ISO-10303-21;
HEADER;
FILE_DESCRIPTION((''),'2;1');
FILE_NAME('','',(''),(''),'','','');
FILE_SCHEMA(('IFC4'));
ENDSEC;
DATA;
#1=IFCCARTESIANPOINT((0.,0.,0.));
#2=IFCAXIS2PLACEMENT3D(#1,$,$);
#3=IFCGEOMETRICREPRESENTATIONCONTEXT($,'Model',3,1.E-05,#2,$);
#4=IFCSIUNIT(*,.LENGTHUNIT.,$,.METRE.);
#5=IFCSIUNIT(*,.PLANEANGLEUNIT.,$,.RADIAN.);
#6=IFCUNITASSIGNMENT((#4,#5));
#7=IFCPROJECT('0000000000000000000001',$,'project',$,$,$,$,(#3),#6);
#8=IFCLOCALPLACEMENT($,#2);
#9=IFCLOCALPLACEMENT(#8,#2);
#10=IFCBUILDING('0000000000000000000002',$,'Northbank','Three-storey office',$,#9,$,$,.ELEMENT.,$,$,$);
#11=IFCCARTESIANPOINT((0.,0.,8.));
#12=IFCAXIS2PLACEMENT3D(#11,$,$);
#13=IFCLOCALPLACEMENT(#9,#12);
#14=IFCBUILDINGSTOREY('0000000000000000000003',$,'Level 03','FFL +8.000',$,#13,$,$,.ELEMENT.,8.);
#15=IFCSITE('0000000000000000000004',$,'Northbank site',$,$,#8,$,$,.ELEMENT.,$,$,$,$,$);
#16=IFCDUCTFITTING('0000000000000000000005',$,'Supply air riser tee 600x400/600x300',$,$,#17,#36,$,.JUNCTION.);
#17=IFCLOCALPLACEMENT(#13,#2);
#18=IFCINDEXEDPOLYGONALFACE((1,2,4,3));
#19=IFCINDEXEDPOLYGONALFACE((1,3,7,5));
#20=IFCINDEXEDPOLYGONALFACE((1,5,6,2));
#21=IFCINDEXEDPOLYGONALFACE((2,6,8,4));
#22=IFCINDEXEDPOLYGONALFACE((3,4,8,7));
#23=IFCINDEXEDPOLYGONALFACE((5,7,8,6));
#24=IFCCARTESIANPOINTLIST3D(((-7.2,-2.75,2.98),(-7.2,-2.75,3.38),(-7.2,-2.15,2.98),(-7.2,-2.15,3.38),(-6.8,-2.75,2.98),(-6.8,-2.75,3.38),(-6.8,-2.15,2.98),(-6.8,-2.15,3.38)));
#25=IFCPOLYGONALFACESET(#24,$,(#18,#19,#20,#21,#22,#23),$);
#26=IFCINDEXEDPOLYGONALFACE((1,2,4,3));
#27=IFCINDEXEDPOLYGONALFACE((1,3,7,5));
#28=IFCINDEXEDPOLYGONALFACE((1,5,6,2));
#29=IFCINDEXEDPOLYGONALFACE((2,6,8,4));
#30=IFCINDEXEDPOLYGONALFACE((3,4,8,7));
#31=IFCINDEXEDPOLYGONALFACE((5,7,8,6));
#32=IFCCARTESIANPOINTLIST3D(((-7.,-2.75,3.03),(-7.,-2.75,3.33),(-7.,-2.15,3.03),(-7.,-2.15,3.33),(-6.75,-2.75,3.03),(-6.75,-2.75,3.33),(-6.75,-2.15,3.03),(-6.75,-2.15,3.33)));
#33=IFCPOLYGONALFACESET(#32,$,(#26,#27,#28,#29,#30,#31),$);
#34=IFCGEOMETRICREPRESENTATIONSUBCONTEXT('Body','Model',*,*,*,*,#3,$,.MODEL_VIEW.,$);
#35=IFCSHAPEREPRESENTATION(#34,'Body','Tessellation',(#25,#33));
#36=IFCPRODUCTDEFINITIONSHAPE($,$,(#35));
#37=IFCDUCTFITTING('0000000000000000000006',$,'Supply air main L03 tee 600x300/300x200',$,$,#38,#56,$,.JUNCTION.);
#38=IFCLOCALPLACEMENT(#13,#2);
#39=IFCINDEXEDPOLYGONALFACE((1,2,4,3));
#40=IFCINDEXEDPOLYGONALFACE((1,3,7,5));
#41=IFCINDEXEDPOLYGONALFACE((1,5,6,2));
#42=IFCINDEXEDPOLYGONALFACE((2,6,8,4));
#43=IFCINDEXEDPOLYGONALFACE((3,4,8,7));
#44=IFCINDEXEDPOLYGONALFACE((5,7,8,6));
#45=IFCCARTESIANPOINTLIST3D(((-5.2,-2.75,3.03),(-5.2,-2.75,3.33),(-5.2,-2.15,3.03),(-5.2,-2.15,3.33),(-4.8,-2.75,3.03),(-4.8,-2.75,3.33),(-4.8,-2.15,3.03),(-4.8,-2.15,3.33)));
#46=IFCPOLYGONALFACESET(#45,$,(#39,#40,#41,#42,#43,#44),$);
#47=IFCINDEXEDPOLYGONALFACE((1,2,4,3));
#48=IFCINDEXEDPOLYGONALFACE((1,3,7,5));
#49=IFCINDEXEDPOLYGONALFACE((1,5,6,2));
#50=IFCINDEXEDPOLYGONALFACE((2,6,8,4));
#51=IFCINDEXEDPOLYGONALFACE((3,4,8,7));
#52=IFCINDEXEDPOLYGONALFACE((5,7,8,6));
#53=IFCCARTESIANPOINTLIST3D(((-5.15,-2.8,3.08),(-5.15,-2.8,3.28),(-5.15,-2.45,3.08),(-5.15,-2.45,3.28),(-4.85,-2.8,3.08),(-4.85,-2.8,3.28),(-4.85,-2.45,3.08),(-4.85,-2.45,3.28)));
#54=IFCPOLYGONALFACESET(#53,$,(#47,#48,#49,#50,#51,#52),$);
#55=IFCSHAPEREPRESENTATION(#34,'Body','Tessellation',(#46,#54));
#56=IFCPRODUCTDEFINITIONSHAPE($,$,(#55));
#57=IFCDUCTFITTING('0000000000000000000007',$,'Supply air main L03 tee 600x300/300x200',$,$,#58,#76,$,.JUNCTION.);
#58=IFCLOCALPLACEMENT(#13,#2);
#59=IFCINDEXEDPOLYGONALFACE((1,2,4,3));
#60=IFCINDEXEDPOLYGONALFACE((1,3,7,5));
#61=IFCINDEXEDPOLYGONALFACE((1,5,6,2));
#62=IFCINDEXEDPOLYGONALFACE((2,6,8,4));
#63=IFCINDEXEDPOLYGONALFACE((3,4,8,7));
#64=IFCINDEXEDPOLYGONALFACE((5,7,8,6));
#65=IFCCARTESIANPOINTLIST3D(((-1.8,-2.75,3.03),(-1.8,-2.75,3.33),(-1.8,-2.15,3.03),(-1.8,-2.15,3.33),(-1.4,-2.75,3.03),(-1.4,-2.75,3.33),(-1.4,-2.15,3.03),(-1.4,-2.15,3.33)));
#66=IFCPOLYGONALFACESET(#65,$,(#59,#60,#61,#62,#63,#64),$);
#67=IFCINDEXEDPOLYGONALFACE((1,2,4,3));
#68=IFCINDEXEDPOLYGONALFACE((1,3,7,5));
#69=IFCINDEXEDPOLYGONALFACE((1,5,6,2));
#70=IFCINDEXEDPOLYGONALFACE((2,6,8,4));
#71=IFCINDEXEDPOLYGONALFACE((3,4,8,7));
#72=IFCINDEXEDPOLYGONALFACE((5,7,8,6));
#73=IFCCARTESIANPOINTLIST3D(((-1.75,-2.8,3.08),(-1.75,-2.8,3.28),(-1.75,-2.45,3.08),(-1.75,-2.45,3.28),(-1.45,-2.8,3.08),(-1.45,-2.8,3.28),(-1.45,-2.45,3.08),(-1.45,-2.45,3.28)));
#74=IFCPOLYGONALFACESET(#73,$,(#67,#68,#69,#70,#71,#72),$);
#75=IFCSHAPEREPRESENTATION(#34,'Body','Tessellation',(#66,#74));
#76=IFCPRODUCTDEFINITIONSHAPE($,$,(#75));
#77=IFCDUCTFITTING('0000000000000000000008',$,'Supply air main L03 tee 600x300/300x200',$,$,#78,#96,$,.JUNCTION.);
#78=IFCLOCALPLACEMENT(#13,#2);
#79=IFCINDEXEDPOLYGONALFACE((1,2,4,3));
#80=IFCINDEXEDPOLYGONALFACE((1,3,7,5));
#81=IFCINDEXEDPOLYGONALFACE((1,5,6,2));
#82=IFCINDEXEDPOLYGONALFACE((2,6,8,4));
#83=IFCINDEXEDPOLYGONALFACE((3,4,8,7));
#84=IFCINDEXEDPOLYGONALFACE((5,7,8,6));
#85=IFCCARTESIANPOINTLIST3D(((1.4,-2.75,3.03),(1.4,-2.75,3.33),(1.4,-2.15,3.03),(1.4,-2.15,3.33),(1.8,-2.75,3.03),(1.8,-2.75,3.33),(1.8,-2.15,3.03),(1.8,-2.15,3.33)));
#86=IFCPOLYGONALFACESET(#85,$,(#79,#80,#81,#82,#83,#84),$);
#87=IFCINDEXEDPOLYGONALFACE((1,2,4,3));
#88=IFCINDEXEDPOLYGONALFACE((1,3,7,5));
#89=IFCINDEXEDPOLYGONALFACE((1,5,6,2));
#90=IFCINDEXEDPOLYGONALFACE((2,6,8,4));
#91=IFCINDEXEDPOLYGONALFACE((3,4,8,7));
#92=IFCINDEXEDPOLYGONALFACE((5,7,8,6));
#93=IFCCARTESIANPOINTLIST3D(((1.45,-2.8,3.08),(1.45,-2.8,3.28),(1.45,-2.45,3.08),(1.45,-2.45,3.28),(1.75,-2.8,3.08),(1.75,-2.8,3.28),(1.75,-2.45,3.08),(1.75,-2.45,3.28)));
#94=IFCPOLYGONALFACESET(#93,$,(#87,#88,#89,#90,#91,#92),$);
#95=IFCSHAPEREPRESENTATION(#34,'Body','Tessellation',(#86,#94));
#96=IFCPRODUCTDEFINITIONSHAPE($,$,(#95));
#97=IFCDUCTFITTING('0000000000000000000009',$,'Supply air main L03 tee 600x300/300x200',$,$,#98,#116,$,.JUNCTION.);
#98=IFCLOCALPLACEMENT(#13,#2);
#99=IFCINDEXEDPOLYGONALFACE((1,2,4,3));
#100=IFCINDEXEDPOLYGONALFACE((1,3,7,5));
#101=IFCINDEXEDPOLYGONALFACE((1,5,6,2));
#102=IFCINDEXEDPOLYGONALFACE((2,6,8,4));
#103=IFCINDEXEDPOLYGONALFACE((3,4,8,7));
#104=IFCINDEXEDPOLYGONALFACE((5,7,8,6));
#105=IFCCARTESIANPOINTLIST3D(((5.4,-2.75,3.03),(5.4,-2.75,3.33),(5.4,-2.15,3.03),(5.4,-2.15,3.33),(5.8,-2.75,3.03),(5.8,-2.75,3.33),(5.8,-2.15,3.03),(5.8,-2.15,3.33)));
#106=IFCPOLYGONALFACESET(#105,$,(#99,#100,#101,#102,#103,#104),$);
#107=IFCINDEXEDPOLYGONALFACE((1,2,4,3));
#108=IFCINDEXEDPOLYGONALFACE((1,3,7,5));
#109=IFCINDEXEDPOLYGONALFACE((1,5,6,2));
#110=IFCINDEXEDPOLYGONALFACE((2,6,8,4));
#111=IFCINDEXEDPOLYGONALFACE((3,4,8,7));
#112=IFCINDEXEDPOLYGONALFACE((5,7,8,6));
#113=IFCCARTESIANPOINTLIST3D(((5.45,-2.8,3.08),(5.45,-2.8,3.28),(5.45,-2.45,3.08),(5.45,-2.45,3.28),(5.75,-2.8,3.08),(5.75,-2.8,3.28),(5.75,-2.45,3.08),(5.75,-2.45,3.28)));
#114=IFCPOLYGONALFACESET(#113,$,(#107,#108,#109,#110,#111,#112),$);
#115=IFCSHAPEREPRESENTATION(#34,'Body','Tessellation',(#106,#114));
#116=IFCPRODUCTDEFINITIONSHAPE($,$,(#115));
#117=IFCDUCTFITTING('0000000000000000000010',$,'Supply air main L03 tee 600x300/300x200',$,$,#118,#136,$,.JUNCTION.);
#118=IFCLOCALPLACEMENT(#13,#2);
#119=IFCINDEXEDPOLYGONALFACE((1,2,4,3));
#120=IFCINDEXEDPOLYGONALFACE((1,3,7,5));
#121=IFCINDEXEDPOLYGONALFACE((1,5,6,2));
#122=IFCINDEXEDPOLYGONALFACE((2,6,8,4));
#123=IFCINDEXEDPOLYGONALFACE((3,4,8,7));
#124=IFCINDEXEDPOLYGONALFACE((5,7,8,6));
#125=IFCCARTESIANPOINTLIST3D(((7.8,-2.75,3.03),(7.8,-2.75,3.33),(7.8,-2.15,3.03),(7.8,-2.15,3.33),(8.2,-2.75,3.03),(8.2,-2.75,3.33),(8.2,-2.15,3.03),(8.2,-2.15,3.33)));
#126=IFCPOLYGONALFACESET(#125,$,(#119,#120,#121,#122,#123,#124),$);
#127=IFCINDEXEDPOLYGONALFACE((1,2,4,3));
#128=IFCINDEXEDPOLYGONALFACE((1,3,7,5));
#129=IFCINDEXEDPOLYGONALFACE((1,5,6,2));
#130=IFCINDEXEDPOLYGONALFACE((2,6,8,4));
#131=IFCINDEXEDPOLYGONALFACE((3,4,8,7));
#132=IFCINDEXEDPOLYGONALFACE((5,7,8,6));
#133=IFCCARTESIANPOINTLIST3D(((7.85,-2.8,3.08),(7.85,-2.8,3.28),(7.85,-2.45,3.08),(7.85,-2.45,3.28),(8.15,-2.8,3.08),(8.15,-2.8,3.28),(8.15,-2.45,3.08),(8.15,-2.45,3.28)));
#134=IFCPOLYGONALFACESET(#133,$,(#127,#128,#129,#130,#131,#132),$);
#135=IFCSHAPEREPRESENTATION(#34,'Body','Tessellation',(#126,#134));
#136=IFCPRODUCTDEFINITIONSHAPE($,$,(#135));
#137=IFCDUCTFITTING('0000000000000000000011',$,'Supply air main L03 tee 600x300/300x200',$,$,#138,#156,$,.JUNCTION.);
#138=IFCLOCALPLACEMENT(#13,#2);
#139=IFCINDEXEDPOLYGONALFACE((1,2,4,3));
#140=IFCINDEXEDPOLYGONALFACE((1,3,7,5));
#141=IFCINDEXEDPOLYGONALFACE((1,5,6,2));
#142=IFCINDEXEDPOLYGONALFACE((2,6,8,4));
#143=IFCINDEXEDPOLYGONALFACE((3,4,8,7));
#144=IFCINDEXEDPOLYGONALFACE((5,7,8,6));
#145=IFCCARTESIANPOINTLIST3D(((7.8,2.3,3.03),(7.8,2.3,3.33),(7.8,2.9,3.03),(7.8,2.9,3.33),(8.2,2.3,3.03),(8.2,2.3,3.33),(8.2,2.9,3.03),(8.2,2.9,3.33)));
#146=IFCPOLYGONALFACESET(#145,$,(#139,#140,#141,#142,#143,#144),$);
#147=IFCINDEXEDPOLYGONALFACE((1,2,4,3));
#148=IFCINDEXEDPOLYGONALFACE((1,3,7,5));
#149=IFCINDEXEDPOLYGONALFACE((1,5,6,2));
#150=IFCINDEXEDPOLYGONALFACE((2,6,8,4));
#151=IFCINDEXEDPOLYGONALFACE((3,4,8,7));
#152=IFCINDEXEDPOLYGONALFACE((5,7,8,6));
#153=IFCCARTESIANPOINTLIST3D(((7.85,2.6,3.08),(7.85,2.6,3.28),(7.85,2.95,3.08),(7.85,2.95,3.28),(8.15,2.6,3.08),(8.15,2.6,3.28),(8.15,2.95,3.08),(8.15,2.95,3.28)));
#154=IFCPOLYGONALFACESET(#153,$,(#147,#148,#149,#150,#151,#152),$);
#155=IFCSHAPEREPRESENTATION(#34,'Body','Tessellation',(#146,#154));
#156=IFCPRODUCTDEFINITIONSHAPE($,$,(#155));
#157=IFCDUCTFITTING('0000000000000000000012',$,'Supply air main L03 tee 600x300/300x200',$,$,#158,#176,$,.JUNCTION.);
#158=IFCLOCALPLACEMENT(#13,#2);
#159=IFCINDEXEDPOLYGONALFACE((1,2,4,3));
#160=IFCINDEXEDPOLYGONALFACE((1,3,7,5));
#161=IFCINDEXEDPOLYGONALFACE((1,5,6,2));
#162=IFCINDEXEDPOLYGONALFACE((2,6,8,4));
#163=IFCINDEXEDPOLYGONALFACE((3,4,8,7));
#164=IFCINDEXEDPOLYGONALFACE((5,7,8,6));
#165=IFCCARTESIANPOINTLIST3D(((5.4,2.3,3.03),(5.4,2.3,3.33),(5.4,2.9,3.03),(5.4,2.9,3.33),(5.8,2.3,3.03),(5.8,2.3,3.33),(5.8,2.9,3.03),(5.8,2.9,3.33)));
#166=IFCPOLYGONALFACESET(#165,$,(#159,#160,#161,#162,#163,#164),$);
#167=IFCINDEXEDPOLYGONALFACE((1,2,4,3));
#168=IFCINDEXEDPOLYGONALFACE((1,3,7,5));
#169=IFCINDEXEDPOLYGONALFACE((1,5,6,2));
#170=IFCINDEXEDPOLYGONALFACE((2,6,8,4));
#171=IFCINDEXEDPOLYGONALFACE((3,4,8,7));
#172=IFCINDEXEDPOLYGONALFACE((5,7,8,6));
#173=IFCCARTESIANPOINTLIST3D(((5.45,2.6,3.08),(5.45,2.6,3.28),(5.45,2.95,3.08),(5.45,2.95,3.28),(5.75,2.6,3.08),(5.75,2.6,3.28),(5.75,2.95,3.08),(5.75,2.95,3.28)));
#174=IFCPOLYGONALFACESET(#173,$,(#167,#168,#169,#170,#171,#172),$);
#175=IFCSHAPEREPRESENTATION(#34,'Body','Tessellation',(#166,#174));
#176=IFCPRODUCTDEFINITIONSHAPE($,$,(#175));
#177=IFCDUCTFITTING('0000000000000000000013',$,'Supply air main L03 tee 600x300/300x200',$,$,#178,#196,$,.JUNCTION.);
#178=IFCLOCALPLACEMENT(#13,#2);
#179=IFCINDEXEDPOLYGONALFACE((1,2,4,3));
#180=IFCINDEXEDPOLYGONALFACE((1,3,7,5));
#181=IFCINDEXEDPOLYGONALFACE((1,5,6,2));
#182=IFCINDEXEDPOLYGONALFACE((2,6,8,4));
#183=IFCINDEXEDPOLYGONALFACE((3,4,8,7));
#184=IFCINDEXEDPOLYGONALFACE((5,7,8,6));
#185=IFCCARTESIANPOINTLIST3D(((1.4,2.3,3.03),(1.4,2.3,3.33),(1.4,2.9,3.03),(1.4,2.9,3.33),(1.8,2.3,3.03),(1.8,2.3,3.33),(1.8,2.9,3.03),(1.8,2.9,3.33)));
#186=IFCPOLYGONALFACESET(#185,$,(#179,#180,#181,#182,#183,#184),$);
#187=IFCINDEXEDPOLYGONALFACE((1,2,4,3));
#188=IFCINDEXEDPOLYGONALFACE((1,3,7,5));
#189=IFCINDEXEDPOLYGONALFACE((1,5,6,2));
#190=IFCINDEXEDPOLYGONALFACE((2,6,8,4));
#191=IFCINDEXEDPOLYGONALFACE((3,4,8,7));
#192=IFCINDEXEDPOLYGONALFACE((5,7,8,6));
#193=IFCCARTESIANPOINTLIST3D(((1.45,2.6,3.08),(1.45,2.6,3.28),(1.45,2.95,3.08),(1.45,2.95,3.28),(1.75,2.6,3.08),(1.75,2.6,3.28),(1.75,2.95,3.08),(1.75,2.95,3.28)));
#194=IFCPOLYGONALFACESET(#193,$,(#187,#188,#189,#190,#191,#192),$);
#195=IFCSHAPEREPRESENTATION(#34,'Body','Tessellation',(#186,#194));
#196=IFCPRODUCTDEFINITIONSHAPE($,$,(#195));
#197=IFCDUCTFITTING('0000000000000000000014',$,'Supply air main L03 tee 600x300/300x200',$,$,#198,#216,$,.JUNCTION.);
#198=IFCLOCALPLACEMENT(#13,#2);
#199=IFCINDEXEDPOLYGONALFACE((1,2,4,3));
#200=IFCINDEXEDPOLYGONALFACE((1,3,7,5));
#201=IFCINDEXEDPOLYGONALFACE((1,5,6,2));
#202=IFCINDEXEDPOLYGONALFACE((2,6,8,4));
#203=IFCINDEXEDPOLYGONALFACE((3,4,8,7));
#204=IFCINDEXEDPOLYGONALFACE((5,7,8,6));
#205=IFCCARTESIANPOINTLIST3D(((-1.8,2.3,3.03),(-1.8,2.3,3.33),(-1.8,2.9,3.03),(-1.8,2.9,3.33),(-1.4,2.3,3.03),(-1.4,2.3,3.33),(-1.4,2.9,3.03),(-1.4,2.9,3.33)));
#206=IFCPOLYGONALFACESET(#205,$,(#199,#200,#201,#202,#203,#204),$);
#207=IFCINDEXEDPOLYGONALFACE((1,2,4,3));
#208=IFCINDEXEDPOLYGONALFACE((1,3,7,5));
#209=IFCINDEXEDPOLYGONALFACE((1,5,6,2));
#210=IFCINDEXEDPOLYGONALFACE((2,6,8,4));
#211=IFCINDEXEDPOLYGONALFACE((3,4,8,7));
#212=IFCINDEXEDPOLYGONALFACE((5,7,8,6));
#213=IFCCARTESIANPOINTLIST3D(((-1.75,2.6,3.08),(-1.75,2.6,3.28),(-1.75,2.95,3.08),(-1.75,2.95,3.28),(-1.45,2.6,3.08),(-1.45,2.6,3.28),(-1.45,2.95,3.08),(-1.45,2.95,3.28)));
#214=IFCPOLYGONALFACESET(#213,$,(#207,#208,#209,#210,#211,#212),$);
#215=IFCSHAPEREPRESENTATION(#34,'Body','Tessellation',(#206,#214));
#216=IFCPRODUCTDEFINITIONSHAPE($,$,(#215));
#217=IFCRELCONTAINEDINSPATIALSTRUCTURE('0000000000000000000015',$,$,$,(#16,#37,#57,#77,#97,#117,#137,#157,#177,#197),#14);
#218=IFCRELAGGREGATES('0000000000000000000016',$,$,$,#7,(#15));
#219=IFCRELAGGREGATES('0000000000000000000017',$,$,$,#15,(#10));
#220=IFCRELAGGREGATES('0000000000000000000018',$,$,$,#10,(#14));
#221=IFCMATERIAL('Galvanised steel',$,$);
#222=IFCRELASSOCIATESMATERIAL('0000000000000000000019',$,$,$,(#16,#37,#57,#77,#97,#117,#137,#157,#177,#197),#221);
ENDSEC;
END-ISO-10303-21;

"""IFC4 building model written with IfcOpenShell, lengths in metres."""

from ifc_helpers import new_model, si_unit, frame, origin, place, context, subcontext, project, spatial, rectangle, extrude, material, element, save


model = new_model("IFC4")

# Units and contexts
model_context = context("Model", 3, precision=1e-05, world=origin())
body_context = subcontext(model_context, "Body", "Model", "MODEL_VIEW")
ifc_project = project(units=[si_unit("LENGTHUNIT", "METRE"), si_unit("PLANEANGLEUNIT", "RADIAN")], contexts=[model_context])

# Site, building, storey
site_placement = place(None, origin())
site = spatial("IfcSite", under=ifc_project, at=site_placement, Name="Northbank site", CompositionType="ELEMENT")
building_placement = place(site_placement, origin())
building = spatial("IfcBuilding", under=site, at=building_placement, Name="Northbank", Description="Three-storey office", CompositionType="ELEMENT")
storey_placement = place(building_placement, frame((0.0, 0.0, 8.0)))
storey = spatial("IfcBuildingStorey", under=building, at=storey_placement, Name="Level 03", Description="FFL +8.000", CompositionType="ELEMENT", Elevation=8.0)

# Duct fitting
ifc_material_1 = material(Name="Galvanised steel")
duct_fitting_1_placement = place(storey_placement, frame((0.0, 0.0, -8.0)))
element("IfcDuctFitting", 1, at=duct_fitting_1_placement, inside=storey, material=ifc_material_1, Name="Supply air riser tee 600x400/600x300", PredefinedType="JUNCTION", context=body_context, shape_type="SweptSolid", body=[
    extrude(rectangle(XDim=0.6, YDim=0.4), frame((-7.0, -2.45, 11.38), z_axis=(0.0, 0.0, -1.0), x_axis=(0.0, -1.0, 0.0)), (0.0, 0.0, 1.0), 0.4),
    extrude(rectangle(XDim=0.6, YDim=0.3), frame((-7.0, -2.45, 11.18), z_axis=(1.0, 0.0, 0.0), x_axis=(0.0, 1.0, 0.0)), (0.0, 0.0, 1.0), 0.25),
])

# Duct fitting
duct_fitting_2_placement = place(storey_placement, frame((0.0, 0.0, -8.0)))
element("IfcDuctFitting", 2, at=duct_fitting_2_placement, inside=storey, material=ifc_material_1, Name="Supply air main L03 tee 600x300/300x200", PredefinedType="JUNCTION", context=body_context, shape_type="SweptSolid", body=[
    extrude(rectangle(XDim=0.6, YDim=0.3), frame((-5.2, -2.45, 11.18), z_axis=(1.0, 0.0, 0.0), x_axis=(0.0, 1.0, 0.0)), (0.0, 0.0, 1.0), 0.4),
    extrude(rectangle(XDim=0.3, YDim=0.2), frame((-5.0, -2.45, 11.18), z_axis=(0.0, -1.0, 0.0), x_axis=(1.0, 0.0, 0.0)), (0.0, 0.0, 1.0), 0.35),
])

# Duct fitting
duct_fitting_3_placement = place(storey_placement, frame((0.0, 0.0, -8.0)))
element("IfcDuctFitting", 3, at=duct_fitting_3_placement, inside=storey, material=ifc_material_1, Name="Supply air main L03 tee 600x300/300x200", PredefinedType="JUNCTION", context=body_context, shape_type="SweptSolid", body=[
    extrude(rectangle(XDim=0.6, YDim=0.3), frame((-1.8, -2.45, 11.18), z_axis=(1.0, 0.0, 0.0), x_axis=(0.0, 1.0, 0.0)), (0.0, 0.0, 1.0), 0.4),
    extrude(rectangle(XDim=0.3, YDim=0.2), frame((-1.6, -2.45, 11.18), z_axis=(0.0, -1.0, 0.0), x_axis=(1.0, 0.0, 0.0)), (0.0, 0.0, 1.0), 0.35),
])

# Duct fitting
duct_fitting_4_placement = place(storey_placement, frame((0.0, 0.0, -8.0)))
element("IfcDuctFitting", 4, at=duct_fitting_4_placement, inside=storey, material=ifc_material_1, Name="Supply air main L03 tee 600x300/300x200", PredefinedType="JUNCTION", context=body_context, shape_type="SweptSolid", body=[
    extrude(rectangle(XDim=0.6, YDim=0.3), frame((1.4, -2.45, 11.18), z_axis=(1.0, 0.0, 0.0), x_axis=(0.0, 1.0, 0.0)), (0.0, 0.0, 1.0), 0.4),
    extrude(rectangle(XDim=0.3, YDim=0.2), frame((1.6, -2.45, 11.18), z_axis=(0.0, -1.0, 0.0), x_axis=(1.0, 0.0, 0.0)), (0.0, 0.0, 1.0), 0.35),
])

# Duct fitting
duct_fitting_5_placement = place(storey_placement, frame((0.0, 0.0, -8.0)))
element("IfcDuctFitting", 5, at=duct_fitting_5_placement, inside=storey, material=ifc_material_1, Name="Supply air main L03 tee 600x300/300x200", PredefinedType="JUNCTION", context=body_context, shape_type="SweptSolid", body=[
    extrude(rectangle(XDim=0.6, YDim=0.3), frame((5.4, -2.45, 11.18), z_axis=(1.0, 0.0, 0.0), x_axis=(0.0, 1.0, 0.0)), (0.0, 0.0, 1.0), 0.4),
    extrude(rectangle(XDim=0.3, YDim=0.2), frame((5.6, -2.45, 11.18), z_axis=(0.0, -1.0, 0.0), x_axis=(1.0, 0.0, 0.0)), (0.0, 0.0, 1.0), 0.35),
])

# Duct fitting
duct_fitting_6_placement = place(storey_placement, frame((0.0, 0.0, -8.0)))
element("IfcDuctFitting", 6, at=duct_fitting_6_placement, inside=storey, material=ifc_material_1, Name="Supply air main L03 tee 600x300/300x200", PredefinedType="JUNCTION", context=body_context, shape_type="SweptSolid", body=[
    extrude(rectangle(XDim=0.6, YDim=0.3), frame((7.8, -2.45, 11.18), z_axis=(1.0, 0.0, 0.0), x_axis=(0.0, 1.0, 0.0)), (0.0, 0.0, 1.0), 0.4),
    extrude(rectangle(XDim=0.3, YDim=0.2), frame((8.0, -2.45, 11.18), z_axis=(0.0, -1.0, 0.0), x_axis=(1.0, 0.0, 0.0)), (0.0, 0.0, 1.0), 0.35),
])

# Duct fitting
duct_fitting_7_placement = place(storey_placement, frame((0.0, 0.0, -8.0)))
element("IfcDuctFitting", 7, at=duct_fitting_7_placement, inside=storey, material=ifc_material_1, Name="Supply air main L03 tee 600x300/300x200", PredefinedType="JUNCTION", context=body_context, shape_type="SweptSolid", body=[
    extrude(rectangle(XDim=0.6, YDim=0.3), frame((8.2, 2.6, 11.18), z_axis=(-1.0, 0.0, 0.0), x_axis=(0.0, -1.0, 0.0)), (0.0, 0.0, 1.0), 0.4),
    extrude(rectangle(XDim=0.3, YDim=0.2), frame((8.0, 2.6, 11.18), z_axis=(0.0, 1.0, 0.0), x_axis=(-1.0, 0.0, 0.0)), (0.0, 0.0, 1.0), 0.35),
])

# Duct fitting
duct_fitting_8_placement = place(storey_placement, frame((0.0, 0.0, -8.0)))
element("IfcDuctFitting", 8, at=duct_fitting_8_placement, inside=storey, material=ifc_material_1, Name="Supply air main L03 tee 600x300/300x200", PredefinedType="JUNCTION", context=body_context, shape_type="SweptSolid", body=[
    extrude(rectangle(XDim=0.6, YDim=0.3), frame((5.8, 2.6, 11.18), z_axis=(-1.0, 0.0, 0.0), x_axis=(0.0, -1.0, 0.0)), (0.0, 0.0, 1.0), 0.4),
    extrude(rectangle(XDim=0.3, YDim=0.2), frame((5.6, 2.6, 11.18), z_axis=(0.0, 1.0, 0.0), x_axis=(-1.0, 0.0, 0.0)), (0.0, 0.0, 1.0), 0.35),
])

# Duct fitting
duct_fitting_9_placement = place(storey_placement, frame((0.0, 0.0, -8.0)))
element("IfcDuctFitting", 9, at=duct_fitting_9_placement, inside=storey, material=ifc_material_1, Name="Supply air main L03 tee 600x300/300x200", PredefinedType="JUNCTION", context=body_context, shape_type="SweptSolid", body=[
    extrude(rectangle(XDim=0.6, YDim=0.3), frame((1.8, 2.6, 11.18), z_axis=(-1.0, 0.0, 0.0), x_axis=(0.0, -1.0, 0.0)), (0.0, 0.0, 1.0), 0.4),
    extrude(rectangle(XDim=0.3, YDim=0.2), frame((1.6, 2.6, 11.18), z_axis=(0.0, 1.0, 0.0), x_axis=(-1.0, 0.0, 0.0)), (0.0, 0.0, 1.0), 0.35),
])

# Duct fitting
duct_fitting_10_placement = place(storey_placement, frame((0.0, 0.0, -8.0)))
element("IfcDuctFitting", 10, at=duct_fitting_10_placement, inside=storey, material=ifc_material_1, Name="Supply air main L03 tee 600x300/300x200", PredefinedType="JUNCTION", context=body_context, shape_type="SweptSolid", body=[
    extrude(rectangle(XDim=0.6, YDim=0.3), frame((-1.4, 2.6, 11.18), z_axis=(-1.0, 0.0, 0.0), x_axis=(0.0, -1.0, 0.0)), (0.0, 0.0, 1.0), 0.4),
    extrude(rectangle(XDim=0.3, YDim=0.2), frame((-1.6, 2.6, 11.18), z_axis=(0.0, 1.0, 0.0), x_axis=(-1.0, 0.0, 0.0)), (0.0, 0.0, 1.0), 0.35),
])

save(model, "model.ifc")
